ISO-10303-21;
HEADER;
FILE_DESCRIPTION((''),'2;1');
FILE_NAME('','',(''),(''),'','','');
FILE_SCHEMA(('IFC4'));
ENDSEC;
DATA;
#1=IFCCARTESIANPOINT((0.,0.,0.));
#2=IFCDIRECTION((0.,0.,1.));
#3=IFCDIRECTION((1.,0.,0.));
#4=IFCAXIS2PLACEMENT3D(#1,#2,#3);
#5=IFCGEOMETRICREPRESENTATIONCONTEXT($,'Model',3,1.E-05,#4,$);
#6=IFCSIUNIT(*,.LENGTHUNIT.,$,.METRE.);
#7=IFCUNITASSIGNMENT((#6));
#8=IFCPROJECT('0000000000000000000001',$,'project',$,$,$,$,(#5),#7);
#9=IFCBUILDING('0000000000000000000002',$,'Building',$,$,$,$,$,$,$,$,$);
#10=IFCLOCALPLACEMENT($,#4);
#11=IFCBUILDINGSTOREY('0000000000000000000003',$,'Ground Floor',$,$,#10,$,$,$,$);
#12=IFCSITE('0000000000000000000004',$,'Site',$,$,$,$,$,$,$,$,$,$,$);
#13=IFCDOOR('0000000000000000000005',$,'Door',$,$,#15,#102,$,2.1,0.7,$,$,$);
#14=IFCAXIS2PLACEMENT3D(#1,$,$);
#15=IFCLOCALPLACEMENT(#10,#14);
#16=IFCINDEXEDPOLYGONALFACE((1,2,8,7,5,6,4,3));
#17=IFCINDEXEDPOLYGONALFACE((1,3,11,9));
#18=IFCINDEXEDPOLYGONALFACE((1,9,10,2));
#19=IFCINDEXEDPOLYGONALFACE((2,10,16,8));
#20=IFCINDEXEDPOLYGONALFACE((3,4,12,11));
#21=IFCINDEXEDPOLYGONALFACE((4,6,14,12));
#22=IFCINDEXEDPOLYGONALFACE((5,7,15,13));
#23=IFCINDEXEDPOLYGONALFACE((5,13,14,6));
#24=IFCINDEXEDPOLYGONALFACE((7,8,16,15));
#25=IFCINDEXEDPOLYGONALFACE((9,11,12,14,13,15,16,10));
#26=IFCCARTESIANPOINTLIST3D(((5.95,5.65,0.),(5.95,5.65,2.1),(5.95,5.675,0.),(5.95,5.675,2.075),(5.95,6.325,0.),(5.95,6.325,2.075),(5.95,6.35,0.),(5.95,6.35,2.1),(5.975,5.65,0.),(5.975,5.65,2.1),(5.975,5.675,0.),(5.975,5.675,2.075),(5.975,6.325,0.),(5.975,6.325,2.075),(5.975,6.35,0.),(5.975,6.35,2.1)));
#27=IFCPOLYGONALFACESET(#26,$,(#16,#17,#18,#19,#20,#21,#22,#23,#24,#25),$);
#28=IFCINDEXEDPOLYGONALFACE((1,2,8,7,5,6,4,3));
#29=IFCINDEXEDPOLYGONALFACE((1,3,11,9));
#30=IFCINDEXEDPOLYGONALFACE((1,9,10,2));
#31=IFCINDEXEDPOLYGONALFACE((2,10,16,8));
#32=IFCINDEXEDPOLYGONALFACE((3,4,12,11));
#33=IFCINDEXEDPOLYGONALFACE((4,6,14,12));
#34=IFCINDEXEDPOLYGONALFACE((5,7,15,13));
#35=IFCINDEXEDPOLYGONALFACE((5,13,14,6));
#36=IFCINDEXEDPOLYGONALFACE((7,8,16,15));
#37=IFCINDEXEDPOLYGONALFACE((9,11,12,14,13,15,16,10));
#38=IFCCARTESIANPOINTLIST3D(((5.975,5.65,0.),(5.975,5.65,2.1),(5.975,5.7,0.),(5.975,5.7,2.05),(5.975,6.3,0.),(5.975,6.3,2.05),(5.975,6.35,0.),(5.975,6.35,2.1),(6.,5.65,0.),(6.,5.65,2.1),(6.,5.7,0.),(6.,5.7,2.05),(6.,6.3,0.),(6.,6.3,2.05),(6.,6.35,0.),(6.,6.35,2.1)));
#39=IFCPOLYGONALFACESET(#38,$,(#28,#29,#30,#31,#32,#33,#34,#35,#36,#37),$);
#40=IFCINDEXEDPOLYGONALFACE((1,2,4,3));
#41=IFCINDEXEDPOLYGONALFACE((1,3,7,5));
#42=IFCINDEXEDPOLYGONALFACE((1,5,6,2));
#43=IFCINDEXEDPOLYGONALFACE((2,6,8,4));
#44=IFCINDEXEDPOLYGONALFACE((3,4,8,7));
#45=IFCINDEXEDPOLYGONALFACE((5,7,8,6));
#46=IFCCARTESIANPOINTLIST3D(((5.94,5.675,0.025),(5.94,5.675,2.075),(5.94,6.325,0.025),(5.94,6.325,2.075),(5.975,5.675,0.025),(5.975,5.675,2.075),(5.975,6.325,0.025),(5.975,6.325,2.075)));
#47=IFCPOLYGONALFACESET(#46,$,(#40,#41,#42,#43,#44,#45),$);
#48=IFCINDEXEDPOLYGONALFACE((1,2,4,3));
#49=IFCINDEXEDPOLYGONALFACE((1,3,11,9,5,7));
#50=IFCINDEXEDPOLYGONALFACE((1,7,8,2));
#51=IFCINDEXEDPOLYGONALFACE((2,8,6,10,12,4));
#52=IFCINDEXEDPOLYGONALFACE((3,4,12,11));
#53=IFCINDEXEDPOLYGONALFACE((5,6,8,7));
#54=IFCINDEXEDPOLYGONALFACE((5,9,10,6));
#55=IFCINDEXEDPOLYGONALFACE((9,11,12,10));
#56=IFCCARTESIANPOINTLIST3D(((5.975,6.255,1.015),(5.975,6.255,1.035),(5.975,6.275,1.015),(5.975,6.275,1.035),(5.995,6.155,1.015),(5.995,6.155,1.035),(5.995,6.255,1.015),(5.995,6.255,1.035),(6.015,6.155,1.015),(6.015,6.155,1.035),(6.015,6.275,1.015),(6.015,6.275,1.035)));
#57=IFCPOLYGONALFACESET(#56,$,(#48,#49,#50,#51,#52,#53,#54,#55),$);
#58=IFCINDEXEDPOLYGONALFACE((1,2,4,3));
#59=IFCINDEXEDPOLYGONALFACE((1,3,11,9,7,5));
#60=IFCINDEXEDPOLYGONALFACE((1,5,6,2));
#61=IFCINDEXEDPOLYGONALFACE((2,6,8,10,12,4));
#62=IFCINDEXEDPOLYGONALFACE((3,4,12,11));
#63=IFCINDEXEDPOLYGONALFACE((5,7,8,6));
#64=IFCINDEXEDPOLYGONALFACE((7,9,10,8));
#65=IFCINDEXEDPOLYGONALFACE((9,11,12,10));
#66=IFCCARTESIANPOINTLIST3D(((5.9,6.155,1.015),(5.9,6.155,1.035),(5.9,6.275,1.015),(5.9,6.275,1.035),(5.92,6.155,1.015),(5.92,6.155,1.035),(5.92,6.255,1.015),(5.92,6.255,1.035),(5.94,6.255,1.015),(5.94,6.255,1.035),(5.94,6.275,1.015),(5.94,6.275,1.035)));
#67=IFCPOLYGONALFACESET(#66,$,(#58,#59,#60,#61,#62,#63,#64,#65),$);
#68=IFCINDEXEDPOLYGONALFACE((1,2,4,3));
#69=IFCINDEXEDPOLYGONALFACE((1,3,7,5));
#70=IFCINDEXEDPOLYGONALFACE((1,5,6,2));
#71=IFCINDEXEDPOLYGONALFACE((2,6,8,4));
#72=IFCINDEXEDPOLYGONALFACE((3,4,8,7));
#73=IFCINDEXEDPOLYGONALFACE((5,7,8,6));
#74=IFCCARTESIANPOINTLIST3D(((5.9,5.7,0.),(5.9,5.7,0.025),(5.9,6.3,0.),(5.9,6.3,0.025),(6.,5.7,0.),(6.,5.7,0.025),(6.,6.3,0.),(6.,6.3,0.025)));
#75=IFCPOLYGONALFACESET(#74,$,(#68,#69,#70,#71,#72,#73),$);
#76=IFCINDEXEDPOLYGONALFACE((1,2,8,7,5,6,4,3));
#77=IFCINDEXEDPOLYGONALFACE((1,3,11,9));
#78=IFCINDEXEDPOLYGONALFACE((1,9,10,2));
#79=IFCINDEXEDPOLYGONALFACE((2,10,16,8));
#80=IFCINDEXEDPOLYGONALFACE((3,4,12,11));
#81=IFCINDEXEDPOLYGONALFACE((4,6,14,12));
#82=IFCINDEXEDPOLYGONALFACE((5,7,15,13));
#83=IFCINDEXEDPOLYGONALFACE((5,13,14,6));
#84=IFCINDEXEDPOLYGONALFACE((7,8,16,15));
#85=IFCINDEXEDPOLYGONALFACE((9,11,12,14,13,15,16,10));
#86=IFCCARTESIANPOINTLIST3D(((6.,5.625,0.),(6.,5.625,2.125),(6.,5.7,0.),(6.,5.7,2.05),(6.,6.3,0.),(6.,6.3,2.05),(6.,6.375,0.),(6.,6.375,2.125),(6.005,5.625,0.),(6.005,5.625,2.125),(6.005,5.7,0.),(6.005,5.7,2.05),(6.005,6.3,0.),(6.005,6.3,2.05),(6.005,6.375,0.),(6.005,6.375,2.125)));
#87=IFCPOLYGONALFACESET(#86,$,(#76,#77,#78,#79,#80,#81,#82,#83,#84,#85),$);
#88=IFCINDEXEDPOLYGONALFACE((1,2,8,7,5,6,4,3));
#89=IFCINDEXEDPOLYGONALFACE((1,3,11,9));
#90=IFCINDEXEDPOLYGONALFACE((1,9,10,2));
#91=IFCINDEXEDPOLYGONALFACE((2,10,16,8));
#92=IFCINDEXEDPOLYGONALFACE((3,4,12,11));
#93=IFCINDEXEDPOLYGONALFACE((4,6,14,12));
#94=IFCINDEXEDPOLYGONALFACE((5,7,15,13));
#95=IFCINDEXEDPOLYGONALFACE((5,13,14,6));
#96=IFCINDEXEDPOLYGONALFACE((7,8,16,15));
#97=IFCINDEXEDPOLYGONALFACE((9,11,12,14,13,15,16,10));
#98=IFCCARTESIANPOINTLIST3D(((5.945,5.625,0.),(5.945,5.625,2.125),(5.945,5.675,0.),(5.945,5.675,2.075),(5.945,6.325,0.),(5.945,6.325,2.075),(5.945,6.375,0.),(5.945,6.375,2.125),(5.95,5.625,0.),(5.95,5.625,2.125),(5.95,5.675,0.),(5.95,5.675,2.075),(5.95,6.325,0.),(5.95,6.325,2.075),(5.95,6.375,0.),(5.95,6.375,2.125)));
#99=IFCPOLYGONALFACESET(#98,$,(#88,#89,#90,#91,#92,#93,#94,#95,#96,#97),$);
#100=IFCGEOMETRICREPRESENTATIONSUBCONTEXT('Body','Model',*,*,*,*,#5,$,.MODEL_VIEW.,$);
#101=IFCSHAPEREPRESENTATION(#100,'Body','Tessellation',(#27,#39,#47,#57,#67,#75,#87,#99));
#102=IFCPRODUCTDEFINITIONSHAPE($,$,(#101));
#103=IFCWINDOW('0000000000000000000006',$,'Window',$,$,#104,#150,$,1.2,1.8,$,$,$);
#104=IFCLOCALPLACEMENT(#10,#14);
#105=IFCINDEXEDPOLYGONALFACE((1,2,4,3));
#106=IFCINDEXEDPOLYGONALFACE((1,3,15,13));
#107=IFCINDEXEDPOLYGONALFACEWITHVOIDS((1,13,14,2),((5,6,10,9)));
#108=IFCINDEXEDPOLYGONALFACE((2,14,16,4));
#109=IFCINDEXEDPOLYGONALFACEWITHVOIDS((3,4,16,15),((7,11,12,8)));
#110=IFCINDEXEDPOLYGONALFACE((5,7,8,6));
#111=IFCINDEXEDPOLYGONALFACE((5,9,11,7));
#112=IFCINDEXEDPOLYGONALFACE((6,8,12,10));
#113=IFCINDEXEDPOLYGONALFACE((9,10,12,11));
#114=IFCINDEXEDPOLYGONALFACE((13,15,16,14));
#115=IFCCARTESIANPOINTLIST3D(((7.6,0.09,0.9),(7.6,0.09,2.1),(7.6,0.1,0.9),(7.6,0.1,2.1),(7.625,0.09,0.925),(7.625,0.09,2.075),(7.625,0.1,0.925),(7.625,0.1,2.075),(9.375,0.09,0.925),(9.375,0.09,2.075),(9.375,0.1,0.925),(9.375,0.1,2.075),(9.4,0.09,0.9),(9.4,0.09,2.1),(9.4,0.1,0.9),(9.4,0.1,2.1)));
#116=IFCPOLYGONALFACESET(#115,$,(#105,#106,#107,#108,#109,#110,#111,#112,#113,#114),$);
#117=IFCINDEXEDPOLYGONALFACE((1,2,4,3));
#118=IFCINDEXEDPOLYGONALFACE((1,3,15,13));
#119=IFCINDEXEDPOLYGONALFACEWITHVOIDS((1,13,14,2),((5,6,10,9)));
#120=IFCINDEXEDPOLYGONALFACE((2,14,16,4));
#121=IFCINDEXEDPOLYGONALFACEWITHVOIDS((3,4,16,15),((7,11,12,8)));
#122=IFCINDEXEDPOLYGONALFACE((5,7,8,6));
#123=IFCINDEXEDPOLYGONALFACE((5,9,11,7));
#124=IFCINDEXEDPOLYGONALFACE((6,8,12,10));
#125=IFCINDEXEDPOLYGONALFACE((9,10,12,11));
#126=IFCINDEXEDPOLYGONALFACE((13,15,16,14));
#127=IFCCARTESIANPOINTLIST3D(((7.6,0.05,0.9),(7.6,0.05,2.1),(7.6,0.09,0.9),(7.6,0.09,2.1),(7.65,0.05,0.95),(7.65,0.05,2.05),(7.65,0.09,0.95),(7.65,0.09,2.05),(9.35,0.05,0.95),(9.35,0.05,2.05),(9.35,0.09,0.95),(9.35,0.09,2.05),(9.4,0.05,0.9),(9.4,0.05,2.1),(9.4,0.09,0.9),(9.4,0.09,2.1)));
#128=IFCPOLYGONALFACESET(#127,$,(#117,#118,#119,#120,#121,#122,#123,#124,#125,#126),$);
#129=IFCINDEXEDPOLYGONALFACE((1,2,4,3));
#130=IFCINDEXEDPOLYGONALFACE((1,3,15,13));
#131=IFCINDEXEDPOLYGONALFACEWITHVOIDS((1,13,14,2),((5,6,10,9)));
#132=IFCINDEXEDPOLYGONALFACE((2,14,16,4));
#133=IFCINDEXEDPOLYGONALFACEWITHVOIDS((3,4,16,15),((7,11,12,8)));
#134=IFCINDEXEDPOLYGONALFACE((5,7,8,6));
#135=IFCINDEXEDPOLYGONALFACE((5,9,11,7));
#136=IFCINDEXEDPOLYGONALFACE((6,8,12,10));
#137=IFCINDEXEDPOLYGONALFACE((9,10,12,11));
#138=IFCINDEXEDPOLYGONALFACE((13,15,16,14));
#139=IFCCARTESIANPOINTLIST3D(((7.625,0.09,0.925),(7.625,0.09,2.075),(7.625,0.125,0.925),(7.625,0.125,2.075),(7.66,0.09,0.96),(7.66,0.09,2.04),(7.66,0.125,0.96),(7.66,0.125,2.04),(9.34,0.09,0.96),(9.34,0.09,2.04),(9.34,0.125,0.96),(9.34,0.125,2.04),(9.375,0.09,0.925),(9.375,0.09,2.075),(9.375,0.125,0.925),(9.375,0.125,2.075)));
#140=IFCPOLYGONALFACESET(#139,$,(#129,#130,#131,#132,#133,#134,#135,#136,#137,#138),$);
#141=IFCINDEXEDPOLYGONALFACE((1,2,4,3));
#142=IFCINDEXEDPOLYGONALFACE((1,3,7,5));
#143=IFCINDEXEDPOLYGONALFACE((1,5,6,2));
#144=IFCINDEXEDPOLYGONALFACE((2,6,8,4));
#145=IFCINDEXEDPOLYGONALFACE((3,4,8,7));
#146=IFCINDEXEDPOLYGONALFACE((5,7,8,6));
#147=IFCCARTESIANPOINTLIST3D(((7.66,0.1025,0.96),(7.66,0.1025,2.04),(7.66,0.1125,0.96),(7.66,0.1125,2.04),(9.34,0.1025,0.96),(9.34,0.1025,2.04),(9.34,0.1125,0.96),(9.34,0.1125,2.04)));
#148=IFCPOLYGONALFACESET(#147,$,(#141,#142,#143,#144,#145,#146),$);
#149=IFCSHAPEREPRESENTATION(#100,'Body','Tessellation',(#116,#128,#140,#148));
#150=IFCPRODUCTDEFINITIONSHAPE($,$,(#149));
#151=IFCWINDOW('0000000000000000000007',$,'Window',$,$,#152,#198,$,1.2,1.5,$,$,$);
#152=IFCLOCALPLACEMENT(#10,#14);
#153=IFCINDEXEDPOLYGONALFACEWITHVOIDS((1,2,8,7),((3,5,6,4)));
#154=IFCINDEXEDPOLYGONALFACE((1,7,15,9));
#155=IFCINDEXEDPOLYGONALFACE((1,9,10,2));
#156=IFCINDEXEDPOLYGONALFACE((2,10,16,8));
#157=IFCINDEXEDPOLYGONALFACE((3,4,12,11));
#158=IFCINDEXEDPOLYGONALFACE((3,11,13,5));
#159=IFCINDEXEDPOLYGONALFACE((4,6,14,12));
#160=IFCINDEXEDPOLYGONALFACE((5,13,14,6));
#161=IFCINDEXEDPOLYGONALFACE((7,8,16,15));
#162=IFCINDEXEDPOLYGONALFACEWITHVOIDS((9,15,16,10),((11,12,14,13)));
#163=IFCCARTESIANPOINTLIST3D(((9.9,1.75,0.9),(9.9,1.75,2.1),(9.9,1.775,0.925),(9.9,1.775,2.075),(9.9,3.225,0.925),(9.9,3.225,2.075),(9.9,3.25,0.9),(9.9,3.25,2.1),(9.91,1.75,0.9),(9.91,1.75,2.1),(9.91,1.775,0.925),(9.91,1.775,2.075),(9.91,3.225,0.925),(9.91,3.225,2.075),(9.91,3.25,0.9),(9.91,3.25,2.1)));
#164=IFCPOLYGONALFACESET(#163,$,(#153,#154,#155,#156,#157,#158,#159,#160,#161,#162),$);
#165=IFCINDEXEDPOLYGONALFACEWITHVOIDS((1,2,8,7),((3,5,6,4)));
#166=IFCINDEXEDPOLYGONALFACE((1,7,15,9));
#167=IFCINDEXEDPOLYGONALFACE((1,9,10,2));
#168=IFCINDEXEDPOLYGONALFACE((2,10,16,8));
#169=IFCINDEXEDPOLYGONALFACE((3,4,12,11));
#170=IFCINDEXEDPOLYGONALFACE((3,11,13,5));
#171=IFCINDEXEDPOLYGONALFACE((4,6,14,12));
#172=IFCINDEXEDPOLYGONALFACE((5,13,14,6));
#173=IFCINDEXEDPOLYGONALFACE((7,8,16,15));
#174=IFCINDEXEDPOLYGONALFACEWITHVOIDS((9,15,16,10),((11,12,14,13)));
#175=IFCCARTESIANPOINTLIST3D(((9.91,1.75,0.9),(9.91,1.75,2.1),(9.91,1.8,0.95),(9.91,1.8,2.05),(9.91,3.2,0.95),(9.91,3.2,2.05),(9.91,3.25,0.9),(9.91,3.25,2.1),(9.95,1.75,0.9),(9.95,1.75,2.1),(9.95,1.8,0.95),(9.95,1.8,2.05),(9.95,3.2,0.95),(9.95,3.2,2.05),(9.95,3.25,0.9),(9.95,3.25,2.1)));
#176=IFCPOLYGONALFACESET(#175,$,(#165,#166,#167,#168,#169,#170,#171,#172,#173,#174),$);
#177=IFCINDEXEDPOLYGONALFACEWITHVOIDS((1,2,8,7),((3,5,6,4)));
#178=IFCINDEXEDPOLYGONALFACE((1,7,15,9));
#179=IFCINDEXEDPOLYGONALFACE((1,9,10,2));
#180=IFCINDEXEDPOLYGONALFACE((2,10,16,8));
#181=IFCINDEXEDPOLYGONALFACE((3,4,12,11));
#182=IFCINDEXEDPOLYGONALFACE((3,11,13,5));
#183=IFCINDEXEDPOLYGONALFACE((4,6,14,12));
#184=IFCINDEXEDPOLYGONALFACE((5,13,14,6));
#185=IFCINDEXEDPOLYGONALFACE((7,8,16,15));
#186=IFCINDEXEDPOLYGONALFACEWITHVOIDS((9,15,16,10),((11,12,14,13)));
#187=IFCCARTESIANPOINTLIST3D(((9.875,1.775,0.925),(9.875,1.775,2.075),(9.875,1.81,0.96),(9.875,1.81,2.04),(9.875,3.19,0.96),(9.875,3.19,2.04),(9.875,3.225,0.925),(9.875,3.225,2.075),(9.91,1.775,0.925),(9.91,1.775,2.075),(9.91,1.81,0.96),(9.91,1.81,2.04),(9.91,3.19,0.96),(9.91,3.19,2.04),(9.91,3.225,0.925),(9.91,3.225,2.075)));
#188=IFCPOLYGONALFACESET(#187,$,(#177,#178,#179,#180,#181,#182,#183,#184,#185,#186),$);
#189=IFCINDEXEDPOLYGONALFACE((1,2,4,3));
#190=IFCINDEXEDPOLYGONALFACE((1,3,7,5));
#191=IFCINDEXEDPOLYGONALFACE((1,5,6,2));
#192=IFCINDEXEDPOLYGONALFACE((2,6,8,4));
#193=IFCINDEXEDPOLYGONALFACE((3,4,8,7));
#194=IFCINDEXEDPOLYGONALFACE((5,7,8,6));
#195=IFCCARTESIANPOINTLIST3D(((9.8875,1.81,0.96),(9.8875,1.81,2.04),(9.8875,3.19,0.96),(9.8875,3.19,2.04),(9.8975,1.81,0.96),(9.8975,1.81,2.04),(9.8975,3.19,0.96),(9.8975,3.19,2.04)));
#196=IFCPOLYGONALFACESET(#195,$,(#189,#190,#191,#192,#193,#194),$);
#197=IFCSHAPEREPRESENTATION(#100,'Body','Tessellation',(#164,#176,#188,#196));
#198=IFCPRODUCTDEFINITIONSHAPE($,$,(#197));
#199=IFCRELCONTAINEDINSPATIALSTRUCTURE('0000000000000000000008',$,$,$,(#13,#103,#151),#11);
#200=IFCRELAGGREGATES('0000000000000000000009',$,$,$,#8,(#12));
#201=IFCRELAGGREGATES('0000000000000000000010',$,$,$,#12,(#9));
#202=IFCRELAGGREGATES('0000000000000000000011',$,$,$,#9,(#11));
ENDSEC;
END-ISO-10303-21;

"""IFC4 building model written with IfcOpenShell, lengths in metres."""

from ifc_helpers import new_model, si_unit, frame, origin_with_axes, place, context, subcontext, project, spatial, line, indexed_curve, outline, extrude, element, save


model = new_model("IFC4")

# Units and contexts
model_context = context("Model", 3, precision=1e-05, world=origin_with_axes())
body_context = subcontext(model_context, "Body", "Model", "MODEL_VIEW")
ifc_project = project(units=[si_unit("LENGTHUNIT", "METRE")], contexts=[model_context])

# Site, building, storey
site = spatial("IfcSite", under=ifc_project, Name="Site")
building = spatial("IfcBuilding", under=site, Name="Building")
storey_placement = place(None, origin_with_axes())
storey = spatial("IfcBuildingStorey", under=building, at=storey_placement, Name="Ground Floor")

# Door
door_1_placement = place(storey_placement, frame((6.0, 5.65, 0.0), z_axis=(0.0, 0.0, 1.0), x_axis=(0.0, 1.0, 0.0)))
element("IfcDoor", 1, at=door_1_placement, inside=storey, Name="Door", OverallHeight=2.1, OverallWidth=0.7, context=body_context, shape_type="SweptSolid", body=[
    extrude(outline(indexed_curve([(0.0, 0.0), (0.0, 2.1), (0.7, 2.1), (0.7, 0.0), (0.675, 0.0), (0.675, 2.075), (0.025, 2.075), (0.025, 0.0)], segments=[line(1, 2, 3, 4, 5, 6, 7, 8, 1)])), frame((0.0, 0.025, 0.0), z_axis=(0.0, -1.0, 0.0), x_axis=(1.0, 0.0, 0.0)), (0.0, 0.0, -1.0), 0.025),
    extrude(outline(indexed_curve([(0.0, 0.0), (0.0, 2.1), (0.7, 2.1), (0.7, 0.0), (0.65, 0.0), (0.65, 2.05), (0.05, 2.05), (0.05, 0.0)], segments=[line(1, 2, 3, 4, 5, 6, 7, 8, 1)])), frame((0.0, 0.0, 0.0), z_axis=(0.0, -1.0, 0.0), x_axis=(1.0, 0.0, 0.0)), (0.0, 0.0, -1.0), 0.025),
    extrude(outline(indexed_curve([(0.0, 0.0), (0.65, 0.0), (0.65, 0.035), (0.0, 0.035)], segments=[line(1, 2, 3, 4, 1)])), frame((0.025, 0.025, 0.025), z_axis=(0.0, 0.0, 1.0), x_axis=(1.0, 0.0, 0.0)), (0.0, 0.0, 1.0), 2.05),
    extrude(outline(indexed_curve([(0.0, 0.0), (0.0, -0.04), (-0.12, -0.04), (-0.12, -0.02), (-0.02, -0.02), (-0.02, 0.0)], segments=[line(1, 2, 3, 4, 5, 6, 1)])), frame((0.625, 0.025, 1.015), z_axis=(0.0, 0.0, 1.0), x_axis=(1.0, 0.0, 0.0)), (0.0, 0.0, 1.0), 0.02),
    extrude(outline(indexed_curve([(0.0, 0.0), (0.0, 0.04), (-0.12, 0.04), (-0.12, 0.02), (-0.02, 0.02), (-0.02, 0.0)], segments=[line(1, 2, 3, 4, 5, 6, 1)])), frame((0.625, 0.06, 1.015), z_axis=(0.0, 0.0, 1.0), x_axis=(1.0, 0.0, 0.0)), (0.0, 0.0, 1.0), 0.02),
    extrude(outline(indexed_curve([(0.0, 0.0), (0.6, 0.0), (0.6, 0.1), (0.0, 0.1)], segments=[line(1, 2, 3, 4, 1)])), frame((0.05, 0.0, 0.0), z_axis=(0.0, 0.0, 1.0), x_axis=(1.0, 0.0, 0.0)), (0.0, 0.0, 1.0), 0.025),
    extrude(outline(indexed_curve([(0.0, 0.0), (0.0, 2.125), (0.75, 2.125), (0.75, 0.0), (0.675, 0.0), (0.675, 2.05), (0.075, 2.05), (0.075, 0.0)], segments=[line(1, 2, 3, 4, 5, 6, 7, 8, 1)])), frame((-0.025, -0.005, 0.0), z_axis=(0.0, -1.0, 0.0), x_axis=(1.0, 0.0, 0.0)), (0.0, 0.0, -1.0), 0.005),
    extrude(outline(indexed_curve([(0.0, 0.0), (0.0, 2.125), (0.75, 2.125), (0.75, 0.0), (0.7, 0.0), (0.7, 2.075), (0.05, 2.075), (0.05, 0.0)], segments=[line(1, 2, 3, 4, 5, 6, 7, 8, 1)])), frame((-0.025, 0.05, 0.0), z_axis=(0.0, -1.0, 0.0), x_axis=(1.0, 0.0, 0.0)), (0.0, 0.0, -1.0), 0.005),
])

# Windows
window_1_placement = place(storey_placement, frame((7.6, 0.0, 0.9), z_axis=(0.0, 0.0, 1.0), x_axis=(1.0, 0.0, 0.0)))
element("IfcWindow", 2, at=window_1_placement, inside=storey, Name="Window", OverallHeight=1.2, OverallWidth=1.8, context=body_context, shape_type="SweptSolid", body=[
    extrude(outline(indexed_curve([(0.0, 0.0), (1.8, 0.0), (1.8, 1.2), (0.0, 1.2)], segments=[line(1, 2, 3, 4, 1)]), holes=[indexed_curve([(0.025, 0.025), (1.775, 0.025), (1.775, 1.175), (0.025, 1.175)], segments=[line(1, 2, 3, 4, 1)])]), frame((0.0, 0.09, 0.0), z_axis=(0.0, -1.0, 0.0), x_axis=(1.0, 0.0, 0.0)), (0.0, 0.0, -1.0), 0.01),
    extrude(outline(indexed_curve([(0.0, 0.0), (1.8, 0.0), (1.8, 1.2), (0.0, 1.2)], segments=[line(1, 2, 3, 4, 1)]), holes=[indexed_curve([(0.05, 0.05), (1.75, 0.05), (1.75, 1.15), (0.05, 1.15)], segments=[line(1, 2, 3, 4, 1)])]), frame((0.0, 0.05, 0.0), z_axis=(0.0, -1.0, 0.0), x_axis=(1.0, 0.0, 0.0)), (0.0, 0.0, -1.0), 0.04),
    extrude(outline(indexed_curve([(0.0, 0.0), (1.75, 0.0), (1.75, 1.15), (0.0, 1.15)], segments=[line(1, 2, 3, 4, 1)]), holes=[indexed_curve([(0.035, 0.035), (1.715, 0.035), (1.715, 1.115), (0.035, 1.115)], segments=[line(1, 2, 3, 4, 1)])]), frame((0.025, 0.09, 0.025), z_axis=(0.0, -1.0, 0.0), x_axis=(1.0, 0.0, 0.0)), (0.0, 0.0, -1.0), 0.035),
    extrude(outline(indexed_curve([(0.035, 0.035), (1.715, 0.035), (1.715, 1.115), (0.035, 1.115)], segments=[line(1, 2, 3, 4, 1)])), frame((0.025, 0.1025, 0.025), z_axis=(0.0, -1.0, 0.0), x_axis=(1.0, 0.0, 0.0)), (0.0, 0.0, -1.0), 0.01),
])
window_2_placement = place(storey_placement, frame((10.0, 1.75, 0.9), z_axis=(0.0, 0.0, 1.0), x_axis=(0.0, 1.0, 0.0)))
element("IfcWindow", 3, at=window_2_placement, inside=storey, Name="Window", OverallHeight=1.2, OverallWidth=1.5, context=body_context, shape_type="SweptSolid", body=[
    extrude(outline(indexed_curve([(0.0, 0.0), (1.5, 0.0), (1.5, 1.2), (0.0, 1.2)], segments=[line(1, 2, 3, 4, 1)]), holes=[indexed_curve([(0.025, 0.025), (1.475, 0.025), (1.475, 1.175), (0.025, 1.175)], segments=[line(1, 2, 3, 4, 1)])]), frame((0.0, 0.09, 0.0), z_axis=(0.0, -1.0, 0.0), x_axis=(1.0, 0.0, 0.0)), (0.0, 0.0, -1.0), 0.01),
    extrude(outline(indexed_curve([(0.0, 0.0), (1.5, 0.0), (1.5, 1.2), (0.0, 1.2)], segments=[line(1, 2, 3, 4, 1)]), holes=[indexed_curve([(0.05, 0.05), (1.45, 0.05), (1.45, 1.15), (0.05, 1.15)], segments=[line(1, 2, 3, 4, 1)])]), frame((0.0, 0.05, 0.0), z_axis=(0.0, -1.0, 0.0), x_axis=(1.0, 0.0, 0.0)), (0.0, 0.0, -1.0), 0.04),
    extrude(outline(indexed_curve([(0.0, 0.0), (1.45, 0.0), (1.45, 1.15), (0.0, 1.15)], segments=[line(1, 2, 3, 4, 1)]), holes=[indexed_curve([(0.035, 0.035), (1.415, 0.035), (1.415, 1.115), (0.035, 1.115)], segments=[line(1, 2, 3, 4, 1)])]), frame((0.025, 0.09, 0.025), z_axis=(0.0, -1.0, 0.0), x_axis=(1.0, 0.0, 0.0)), (0.0, 0.0, -1.0), 0.035),
    extrude(outline(indexed_curve([(0.035, 0.035), (1.415, 0.035), (1.415, 1.115), (0.035, 1.115)], segments=[line(1, 2, 3, 4, 1)])), frame((0.025, 0.1025, 0.025), z_axis=(0.0, -1.0, 0.0), x_axis=(1.0, 0.0, 0.0)), (0.0, 0.0, -1.0), 0.01),
])

save(model, "model.ifc")
